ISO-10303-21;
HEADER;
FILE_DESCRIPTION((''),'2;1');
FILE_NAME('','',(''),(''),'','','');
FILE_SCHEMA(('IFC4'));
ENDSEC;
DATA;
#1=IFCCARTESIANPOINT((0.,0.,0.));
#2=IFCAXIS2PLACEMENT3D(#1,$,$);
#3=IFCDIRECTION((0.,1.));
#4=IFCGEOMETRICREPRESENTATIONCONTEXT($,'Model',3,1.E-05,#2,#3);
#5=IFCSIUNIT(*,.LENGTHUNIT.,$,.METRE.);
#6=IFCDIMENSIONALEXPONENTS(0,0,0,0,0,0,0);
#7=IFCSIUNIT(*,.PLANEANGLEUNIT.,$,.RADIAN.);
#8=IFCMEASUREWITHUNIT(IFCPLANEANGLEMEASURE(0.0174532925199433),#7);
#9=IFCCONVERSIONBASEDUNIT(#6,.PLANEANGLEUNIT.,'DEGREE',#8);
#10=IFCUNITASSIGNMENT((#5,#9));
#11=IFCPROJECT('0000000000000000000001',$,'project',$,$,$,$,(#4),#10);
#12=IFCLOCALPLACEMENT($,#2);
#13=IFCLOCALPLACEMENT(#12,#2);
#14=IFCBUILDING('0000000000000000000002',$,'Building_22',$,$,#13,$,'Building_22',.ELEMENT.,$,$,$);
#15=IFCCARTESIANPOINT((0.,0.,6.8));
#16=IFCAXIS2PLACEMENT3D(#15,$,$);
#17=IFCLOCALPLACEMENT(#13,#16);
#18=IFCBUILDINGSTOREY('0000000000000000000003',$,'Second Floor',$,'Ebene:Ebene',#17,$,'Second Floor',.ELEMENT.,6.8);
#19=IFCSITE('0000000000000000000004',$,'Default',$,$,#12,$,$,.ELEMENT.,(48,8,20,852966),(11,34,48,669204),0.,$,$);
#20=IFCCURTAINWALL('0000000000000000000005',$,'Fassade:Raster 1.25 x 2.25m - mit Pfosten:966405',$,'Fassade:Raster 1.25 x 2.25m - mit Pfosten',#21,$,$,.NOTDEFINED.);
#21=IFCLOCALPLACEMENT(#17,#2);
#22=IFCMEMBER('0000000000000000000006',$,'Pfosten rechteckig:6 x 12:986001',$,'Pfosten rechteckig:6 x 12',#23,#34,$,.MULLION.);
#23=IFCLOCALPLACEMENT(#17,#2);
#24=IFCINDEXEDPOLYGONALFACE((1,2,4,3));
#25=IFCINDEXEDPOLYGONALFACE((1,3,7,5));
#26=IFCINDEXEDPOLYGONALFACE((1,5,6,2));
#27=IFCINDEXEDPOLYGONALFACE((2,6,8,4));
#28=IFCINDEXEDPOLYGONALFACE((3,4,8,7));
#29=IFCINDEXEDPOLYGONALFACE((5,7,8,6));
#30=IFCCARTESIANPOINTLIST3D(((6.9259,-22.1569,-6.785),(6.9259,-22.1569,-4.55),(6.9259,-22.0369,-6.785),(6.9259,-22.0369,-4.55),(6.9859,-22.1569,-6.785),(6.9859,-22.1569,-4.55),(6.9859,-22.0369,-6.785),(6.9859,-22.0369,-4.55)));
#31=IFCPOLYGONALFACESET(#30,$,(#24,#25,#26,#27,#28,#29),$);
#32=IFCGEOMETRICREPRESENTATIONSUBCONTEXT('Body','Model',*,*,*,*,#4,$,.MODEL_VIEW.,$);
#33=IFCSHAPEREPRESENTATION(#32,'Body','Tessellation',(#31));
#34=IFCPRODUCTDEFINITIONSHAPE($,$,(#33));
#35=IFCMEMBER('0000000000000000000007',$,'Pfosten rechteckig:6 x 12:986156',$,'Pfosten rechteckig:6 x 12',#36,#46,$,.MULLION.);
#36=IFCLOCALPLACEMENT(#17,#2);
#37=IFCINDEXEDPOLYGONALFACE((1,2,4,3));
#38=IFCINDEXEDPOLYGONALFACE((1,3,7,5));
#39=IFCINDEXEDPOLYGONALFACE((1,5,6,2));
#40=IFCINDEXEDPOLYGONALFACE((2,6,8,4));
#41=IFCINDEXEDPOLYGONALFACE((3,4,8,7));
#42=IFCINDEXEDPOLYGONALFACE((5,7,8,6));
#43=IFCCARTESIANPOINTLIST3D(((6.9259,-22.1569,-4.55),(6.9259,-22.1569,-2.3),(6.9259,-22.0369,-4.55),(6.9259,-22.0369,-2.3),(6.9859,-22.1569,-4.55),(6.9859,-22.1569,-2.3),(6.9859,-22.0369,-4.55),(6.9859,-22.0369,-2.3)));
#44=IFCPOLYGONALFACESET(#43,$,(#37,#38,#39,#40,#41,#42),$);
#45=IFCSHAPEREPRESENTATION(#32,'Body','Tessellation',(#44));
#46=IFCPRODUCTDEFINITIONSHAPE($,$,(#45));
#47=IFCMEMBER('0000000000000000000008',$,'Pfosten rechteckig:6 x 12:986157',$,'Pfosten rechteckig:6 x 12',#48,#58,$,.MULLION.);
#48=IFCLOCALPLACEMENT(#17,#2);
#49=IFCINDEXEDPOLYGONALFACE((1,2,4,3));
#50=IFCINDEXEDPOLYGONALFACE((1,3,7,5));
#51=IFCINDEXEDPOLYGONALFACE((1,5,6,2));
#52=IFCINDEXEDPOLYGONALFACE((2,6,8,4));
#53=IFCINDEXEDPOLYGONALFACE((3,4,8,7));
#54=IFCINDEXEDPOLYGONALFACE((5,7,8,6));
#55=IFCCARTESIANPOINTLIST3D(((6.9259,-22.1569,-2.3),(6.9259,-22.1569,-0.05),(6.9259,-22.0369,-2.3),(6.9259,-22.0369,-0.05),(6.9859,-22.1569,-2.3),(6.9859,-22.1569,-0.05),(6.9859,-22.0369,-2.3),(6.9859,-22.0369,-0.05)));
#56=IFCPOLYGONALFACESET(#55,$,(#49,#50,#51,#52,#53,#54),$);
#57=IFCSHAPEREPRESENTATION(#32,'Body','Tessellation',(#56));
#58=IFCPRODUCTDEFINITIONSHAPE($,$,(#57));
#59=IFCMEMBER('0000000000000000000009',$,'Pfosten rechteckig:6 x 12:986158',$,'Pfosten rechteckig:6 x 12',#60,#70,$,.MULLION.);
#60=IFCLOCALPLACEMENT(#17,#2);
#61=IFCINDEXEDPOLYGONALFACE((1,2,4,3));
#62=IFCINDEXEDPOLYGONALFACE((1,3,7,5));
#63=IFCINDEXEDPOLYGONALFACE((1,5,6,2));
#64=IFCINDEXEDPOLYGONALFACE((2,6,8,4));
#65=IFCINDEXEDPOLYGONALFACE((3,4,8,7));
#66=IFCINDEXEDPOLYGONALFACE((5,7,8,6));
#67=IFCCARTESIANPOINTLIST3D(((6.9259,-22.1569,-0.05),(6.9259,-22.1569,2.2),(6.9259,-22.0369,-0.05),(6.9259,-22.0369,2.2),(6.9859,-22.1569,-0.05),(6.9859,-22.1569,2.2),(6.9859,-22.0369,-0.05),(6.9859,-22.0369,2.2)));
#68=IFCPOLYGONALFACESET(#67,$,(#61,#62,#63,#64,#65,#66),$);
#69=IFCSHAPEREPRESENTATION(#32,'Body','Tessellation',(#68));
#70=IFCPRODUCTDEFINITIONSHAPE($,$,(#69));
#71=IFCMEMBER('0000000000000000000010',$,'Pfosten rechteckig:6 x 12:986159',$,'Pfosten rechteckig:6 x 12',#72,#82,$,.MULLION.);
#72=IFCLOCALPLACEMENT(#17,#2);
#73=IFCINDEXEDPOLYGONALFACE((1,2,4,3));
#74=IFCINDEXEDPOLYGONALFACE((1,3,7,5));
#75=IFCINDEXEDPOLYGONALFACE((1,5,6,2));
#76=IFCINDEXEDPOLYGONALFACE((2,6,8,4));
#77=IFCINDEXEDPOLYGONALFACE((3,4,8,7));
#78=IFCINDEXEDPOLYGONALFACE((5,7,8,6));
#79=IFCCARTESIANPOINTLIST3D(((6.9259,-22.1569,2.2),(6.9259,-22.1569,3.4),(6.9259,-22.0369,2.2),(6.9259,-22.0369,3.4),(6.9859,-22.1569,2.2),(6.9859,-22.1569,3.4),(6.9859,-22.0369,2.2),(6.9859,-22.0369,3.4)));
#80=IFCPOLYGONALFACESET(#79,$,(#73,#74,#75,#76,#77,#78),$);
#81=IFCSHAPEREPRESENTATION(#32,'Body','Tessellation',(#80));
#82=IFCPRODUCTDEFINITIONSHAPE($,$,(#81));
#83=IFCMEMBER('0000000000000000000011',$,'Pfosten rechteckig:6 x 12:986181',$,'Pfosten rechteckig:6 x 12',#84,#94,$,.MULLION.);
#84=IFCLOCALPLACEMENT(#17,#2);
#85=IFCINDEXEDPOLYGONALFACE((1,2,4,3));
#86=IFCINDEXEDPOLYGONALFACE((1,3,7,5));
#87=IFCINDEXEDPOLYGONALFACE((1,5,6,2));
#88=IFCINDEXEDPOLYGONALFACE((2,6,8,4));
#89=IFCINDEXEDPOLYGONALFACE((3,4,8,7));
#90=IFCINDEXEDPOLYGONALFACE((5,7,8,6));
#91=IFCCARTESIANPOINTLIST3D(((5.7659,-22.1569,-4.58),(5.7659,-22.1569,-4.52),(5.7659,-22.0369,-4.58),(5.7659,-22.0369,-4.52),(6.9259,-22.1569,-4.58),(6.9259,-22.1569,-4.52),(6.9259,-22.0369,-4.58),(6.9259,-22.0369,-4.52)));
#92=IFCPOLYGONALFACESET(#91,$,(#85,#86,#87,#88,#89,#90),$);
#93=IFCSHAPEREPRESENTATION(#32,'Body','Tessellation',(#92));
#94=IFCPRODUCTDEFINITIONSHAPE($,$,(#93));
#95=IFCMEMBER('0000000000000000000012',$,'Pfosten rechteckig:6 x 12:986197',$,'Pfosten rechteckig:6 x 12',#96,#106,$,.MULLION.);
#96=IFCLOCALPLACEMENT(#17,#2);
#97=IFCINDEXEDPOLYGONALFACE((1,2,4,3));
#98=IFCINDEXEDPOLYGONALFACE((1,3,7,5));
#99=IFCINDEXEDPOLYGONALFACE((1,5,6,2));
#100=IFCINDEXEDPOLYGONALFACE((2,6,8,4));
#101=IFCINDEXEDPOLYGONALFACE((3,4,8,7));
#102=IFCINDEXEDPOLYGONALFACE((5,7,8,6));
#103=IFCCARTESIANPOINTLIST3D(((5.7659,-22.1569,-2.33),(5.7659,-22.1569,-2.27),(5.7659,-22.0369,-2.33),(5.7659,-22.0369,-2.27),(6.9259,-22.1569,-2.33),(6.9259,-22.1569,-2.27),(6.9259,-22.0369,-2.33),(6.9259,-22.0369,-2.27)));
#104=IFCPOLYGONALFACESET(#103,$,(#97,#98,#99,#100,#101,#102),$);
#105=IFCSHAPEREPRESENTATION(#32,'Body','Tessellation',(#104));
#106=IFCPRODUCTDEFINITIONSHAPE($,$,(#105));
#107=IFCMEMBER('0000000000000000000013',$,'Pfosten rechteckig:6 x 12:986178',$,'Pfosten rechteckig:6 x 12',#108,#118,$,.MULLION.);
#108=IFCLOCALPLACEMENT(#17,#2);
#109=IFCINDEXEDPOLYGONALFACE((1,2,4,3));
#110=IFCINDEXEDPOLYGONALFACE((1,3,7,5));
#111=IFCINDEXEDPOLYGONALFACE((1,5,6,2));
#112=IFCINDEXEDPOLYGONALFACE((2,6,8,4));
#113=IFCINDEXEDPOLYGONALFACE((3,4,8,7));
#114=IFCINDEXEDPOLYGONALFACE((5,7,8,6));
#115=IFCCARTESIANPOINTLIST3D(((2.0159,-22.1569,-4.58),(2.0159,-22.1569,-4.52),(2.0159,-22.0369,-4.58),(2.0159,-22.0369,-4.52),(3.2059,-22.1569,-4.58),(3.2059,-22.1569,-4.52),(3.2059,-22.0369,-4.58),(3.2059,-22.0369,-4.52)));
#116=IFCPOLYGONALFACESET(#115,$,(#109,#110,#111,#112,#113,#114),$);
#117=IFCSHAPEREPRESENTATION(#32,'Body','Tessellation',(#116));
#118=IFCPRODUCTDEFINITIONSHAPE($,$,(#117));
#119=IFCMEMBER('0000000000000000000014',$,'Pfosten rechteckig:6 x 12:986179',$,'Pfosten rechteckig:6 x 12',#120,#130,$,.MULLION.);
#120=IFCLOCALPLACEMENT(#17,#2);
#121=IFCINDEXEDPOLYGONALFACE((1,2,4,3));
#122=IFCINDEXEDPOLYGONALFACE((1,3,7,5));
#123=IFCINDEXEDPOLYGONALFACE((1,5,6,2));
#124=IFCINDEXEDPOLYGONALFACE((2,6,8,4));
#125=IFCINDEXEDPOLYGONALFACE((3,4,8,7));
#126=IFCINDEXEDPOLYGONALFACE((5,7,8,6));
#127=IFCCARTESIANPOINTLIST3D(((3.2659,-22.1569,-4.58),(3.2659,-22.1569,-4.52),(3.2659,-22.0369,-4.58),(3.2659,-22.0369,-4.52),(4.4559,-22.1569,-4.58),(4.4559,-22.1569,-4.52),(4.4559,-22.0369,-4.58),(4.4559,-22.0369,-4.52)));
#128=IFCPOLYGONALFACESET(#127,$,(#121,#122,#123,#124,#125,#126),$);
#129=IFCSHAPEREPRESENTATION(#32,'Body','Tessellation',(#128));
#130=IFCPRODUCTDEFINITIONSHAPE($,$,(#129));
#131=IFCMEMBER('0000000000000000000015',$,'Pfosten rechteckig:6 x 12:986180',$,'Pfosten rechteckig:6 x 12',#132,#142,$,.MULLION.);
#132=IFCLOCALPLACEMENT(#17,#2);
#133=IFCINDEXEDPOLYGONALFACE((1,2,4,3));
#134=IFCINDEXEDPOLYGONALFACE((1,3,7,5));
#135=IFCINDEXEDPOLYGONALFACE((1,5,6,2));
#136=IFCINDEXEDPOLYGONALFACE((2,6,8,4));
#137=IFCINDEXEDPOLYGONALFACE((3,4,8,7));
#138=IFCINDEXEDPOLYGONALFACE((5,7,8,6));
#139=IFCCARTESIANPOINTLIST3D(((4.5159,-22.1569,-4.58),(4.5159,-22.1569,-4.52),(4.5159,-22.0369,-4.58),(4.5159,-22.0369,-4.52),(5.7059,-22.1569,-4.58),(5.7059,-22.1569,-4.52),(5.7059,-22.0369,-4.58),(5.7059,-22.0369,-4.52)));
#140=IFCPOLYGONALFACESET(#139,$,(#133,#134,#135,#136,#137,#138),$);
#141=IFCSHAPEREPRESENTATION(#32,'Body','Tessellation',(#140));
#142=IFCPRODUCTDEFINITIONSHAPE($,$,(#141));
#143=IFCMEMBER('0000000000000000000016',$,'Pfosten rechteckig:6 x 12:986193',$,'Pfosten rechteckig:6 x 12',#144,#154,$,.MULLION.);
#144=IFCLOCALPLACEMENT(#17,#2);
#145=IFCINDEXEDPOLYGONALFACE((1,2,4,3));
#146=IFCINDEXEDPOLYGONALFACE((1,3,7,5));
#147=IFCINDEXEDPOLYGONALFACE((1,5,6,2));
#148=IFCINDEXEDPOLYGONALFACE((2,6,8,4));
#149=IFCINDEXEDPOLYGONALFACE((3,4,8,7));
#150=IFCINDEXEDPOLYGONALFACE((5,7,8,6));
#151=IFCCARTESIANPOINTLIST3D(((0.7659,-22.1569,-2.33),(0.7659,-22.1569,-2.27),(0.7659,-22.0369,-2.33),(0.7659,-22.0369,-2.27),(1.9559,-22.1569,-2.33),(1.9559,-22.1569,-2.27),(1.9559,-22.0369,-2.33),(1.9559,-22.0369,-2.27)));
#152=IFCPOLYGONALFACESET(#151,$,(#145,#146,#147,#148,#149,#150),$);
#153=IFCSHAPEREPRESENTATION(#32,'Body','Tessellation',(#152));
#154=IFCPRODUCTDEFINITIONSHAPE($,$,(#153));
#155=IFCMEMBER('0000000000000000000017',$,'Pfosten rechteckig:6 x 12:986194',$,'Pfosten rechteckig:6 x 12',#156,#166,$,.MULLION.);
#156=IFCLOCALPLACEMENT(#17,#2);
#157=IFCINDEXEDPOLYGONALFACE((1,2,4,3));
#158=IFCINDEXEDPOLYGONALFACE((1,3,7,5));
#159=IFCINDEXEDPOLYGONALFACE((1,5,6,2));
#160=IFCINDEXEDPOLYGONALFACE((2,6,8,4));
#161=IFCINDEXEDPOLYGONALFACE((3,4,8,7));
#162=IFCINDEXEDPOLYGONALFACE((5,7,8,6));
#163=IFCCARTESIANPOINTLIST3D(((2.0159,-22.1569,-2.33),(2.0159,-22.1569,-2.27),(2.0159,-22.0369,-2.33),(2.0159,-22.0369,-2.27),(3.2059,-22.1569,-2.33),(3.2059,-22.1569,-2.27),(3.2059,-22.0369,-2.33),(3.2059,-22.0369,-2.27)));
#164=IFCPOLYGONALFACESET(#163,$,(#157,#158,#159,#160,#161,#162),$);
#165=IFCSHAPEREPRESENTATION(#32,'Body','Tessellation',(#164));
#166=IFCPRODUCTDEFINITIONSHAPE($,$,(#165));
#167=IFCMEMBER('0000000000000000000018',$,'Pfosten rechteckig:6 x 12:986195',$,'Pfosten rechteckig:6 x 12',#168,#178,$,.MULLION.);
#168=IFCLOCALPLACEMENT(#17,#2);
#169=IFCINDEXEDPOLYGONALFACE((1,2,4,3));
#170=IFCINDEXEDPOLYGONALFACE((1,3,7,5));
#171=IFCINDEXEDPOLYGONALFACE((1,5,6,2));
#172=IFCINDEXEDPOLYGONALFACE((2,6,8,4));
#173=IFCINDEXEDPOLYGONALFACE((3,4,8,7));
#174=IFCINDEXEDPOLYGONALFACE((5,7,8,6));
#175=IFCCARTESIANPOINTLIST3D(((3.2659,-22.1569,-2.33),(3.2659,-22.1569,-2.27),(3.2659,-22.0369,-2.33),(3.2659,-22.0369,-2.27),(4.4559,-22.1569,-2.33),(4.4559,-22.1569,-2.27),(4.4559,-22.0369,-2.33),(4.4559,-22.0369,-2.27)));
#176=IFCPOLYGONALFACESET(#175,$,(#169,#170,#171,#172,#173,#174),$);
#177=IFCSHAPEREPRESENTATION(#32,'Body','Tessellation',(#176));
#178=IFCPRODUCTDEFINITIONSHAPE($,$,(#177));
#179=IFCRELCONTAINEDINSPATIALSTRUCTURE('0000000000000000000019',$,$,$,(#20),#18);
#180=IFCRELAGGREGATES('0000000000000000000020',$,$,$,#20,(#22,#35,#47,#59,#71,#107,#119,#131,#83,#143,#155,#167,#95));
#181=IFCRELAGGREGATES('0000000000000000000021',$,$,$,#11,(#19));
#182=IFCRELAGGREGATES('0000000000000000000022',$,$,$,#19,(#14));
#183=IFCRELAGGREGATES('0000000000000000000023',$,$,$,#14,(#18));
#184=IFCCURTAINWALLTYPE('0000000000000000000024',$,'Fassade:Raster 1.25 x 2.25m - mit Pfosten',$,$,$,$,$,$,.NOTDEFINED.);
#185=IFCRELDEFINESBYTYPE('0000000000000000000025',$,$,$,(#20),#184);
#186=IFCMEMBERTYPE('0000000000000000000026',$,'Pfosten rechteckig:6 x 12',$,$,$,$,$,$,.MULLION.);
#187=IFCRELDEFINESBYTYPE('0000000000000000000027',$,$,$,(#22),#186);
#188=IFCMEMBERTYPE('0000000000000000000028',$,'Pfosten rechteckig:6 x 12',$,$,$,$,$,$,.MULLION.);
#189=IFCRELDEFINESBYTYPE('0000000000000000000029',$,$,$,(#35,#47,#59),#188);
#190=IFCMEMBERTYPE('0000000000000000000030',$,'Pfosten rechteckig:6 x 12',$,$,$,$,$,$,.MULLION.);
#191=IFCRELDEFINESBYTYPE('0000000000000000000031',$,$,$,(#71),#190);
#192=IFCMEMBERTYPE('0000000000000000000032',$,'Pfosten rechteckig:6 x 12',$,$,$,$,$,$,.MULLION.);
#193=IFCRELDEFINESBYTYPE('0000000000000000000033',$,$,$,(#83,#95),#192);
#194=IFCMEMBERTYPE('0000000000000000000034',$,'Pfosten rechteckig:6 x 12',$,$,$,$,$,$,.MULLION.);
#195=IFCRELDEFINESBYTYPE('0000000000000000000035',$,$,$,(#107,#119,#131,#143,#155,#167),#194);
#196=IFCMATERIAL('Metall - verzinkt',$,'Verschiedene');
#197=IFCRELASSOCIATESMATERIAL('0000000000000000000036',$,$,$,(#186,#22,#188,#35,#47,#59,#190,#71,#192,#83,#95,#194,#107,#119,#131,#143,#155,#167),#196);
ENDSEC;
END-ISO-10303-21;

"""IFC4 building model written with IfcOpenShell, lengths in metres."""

from ifc_helpers import new_model, entity, si_unit, converted_unit, direction, frame, origin, place, context, subcontext, project, spatial, indexed_curve, outline, extrude, source, transform, mapped, material, type_object, type_shapes, element, aggregate, save


model = new_model("IFC4")

# Units and contexts
model_context = context("Model", 3, precision=1e-05, world=origin(), true_north=direction((0.0, 1.0)))
body_context = subcontext(model_context, "Body", "Model", "MODEL_VIEW")
ifc_project = project(units=[si_unit("LENGTHUNIT", "METRE"), converted_unit("PLANEANGLEUNIT", "DEGREE", entity("IfcPlaneAngleMeasure", 0.0174532925199433), si_unit("PLANEANGLEUNIT", "RADIAN"), dimensions=[0, 0, 0, 0, 0, 0, 0])], contexts=[model_context])

# Site, building, storey
site_placement = place(None, origin())
site = spatial("IfcSite", under=ifc_project, at=site_placement, Name="Default", CompositionType="ELEMENT", RefLatitude=(48, 8, 20, 852966), RefLongitude=(11, 34, 48, 669204), RefElevation=0.0)
building_placement = place(site_placement, origin())
building = spatial("IfcBuilding", under=site, at=building_placement, Name="Building_22", LongName="Building_22", CompositionType="ELEMENT")
storey_placement = place(building_placement, frame((0.0, 0.0, 6.8)))
storey = spatial("IfcBuildingStorey", under=building, at=storey_placement, Name="Second Floor", ObjectType="Ebene:Ebene", LongName="Second Floor", CompositionType="ELEMENT", Elevation=6.8)

# Curtain wall, members
curtain_wall_type = type_object("IfcCurtainWallType", Name="Fassade:Raster 1.25 x 2.25m - mit Pfosten", PredefinedType="NOTDEFINED")
curtain_wall_placement = place(storey_placement, frame((0.0, 0.0, -6.8)))
curtain_wall = element("IfcCurtainWall", 1, at=curtain_wall_placement, inside=storey, type_object=curtain_wall_type, Name="Fassade:Raster 1.25 x 2.25m - mit Pfosten:966405", ObjectType="Fassade:Raster 1.25 x 2.25m - mit Pfosten", PredefinedType="NOTDEFINED")
ifc_material_1 = material(Name="Metall - verzinkt", Category="Verschiedene")
member_type_1 = type_object("IfcMemberType", Name="Pfosten rechteckig:6 x 12", PredefinedType="MULLION", material=ifc_material_1)
shared_shape_1 = source(origin(), body_context, "Body", "SweptSolid", [
    extrude(outline(indexed_curve([(-0.03, -0.06), (0.03, -0.06), (0.03, 0.06), (-0.03, 0.06), (-0.03, -0.06)], self_intersect=False)), frame((-0.03, 0.0, -2.235), z_axis=(0.0, 0.0, 1.0), x_axis=(-1.0, 0.0, 0.0)), (0.0, 0.0, 1.0), 2.235),
])
type_shapes(member_type_1, [shared_shape_1])
member_1_placement = place(curtain_wall_placement, frame((6.9859, -22.0969, 0.015), z_axis=(0.0, 0.0, -1.0), x_axis=(1.0, 0.0, 0.0)))
member_1 = element("IfcMember", 2, at=member_1_placement, type_object=member_type_1, material=ifc_material_1, Name="Pfosten rechteckig:6 x 12:986001", ObjectType="Pfosten rechteckig:6 x 12", PredefinedType="MULLION", context=body_context, shape_type="MappedRepresentation", body=[
    mapped(shared_shape_1, transform((0.0, 0.0, 0.0), scale=1.0)),
])
member_type_2 = type_object("IfcMemberType", Name="Pfosten rechteckig:6 x 12", PredefinedType="MULLION", material=ifc_material_1)
shared_shape_2 = source(origin(), body_context, "Body", "SweptSolid", [
    extrude(outline(indexed_curve([(-0.03, -0.06), (0.03, -0.06), (0.03, 0.06), (-0.03, 0.06), (-0.03, -0.06)], self_intersect=False)), frame((-0.03, 0.0, -2.25), z_axis=(0.0, 0.0, 1.0), x_axis=(-1.0, 0.0, 0.0)), (0.0, 0.0, 1.0), 2.25),
])
type_shapes(member_type_2, [shared_shape_2])
member_2_placement = place(curtain_wall_placement, frame((6.9859, -22.0969, 2.25), z_axis=(0.0, 0.0, -1.0), x_axis=(1.0, 0.0, 0.0)))
member_2 = element("IfcMember", 3, at=member_2_placement, type_object=member_type_2, material=ifc_material_1, Name="Pfosten rechteckig:6 x 12:986156", ObjectType="Pfosten rechteckig:6 x 12", PredefinedType="MULLION", context=body_context, shape_type="MappedRepresentation", body=[
    mapped(shared_shape_2, transform((0.0, 0.0, 0.0), scale=1.0)),
])
member_3_placement = place(curtain_wall_placement, frame((6.9859, -22.0969, 4.5), z_axis=(0.0, 0.0, -1.0), x_axis=(1.0, 0.0, 0.0)))
member_3 = element("IfcMember", 4, at=member_3_placement, type_object=member_type_2, material=ifc_material_1, Name="Pfosten rechteckig:6 x 12:986157", ObjectType="Pfosten rechteckig:6 x 12", PredefinedType="MULLION", context=body_context, shape_type="MappedRepresentation", body=[
    mapped(shared_shape_2, transform((0.0, 0.0, 0.0), scale=1.0)),
])
member_4_placement = place(curtain_wall_placement, frame((6.9859, -22.0969, 6.75), z_axis=(0.0, 0.0, -1.0), x_axis=(1.0, 0.0, 0.0)))
member_4 = element("IfcMember", 5, at=member_4_placement, type_object=member_type_2, material=ifc_material_1, Name="Pfosten rechteckig:6 x 12:986158", ObjectType="Pfosten rechteckig:6 x 12", PredefinedType="MULLION", context=body_context, shape_type="MappedRepresentation", body=[
    mapped(shared_shape_2, transform((0.0, 0.0, 0.0), scale=1.0)),
])
member_type_3 = type_object("IfcMemberType", Name="Pfosten rechteckig:6 x 12", PredefinedType="MULLION", material=ifc_material_1)
shared_shape_3 = source(origin(), body_context, "Body", "SweptSolid", [
    extrude(outline(indexed_curve([(-0.03, -0.06), (0.03, -0.06), (0.03, 0.06), (-0.03, 0.06), (-0.03, -0.06)], self_intersect=False)), frame((-0.03, 0.0, -1.2), z_axis=(0.0, 0.0, 1.0), x_axis=(-1.0, 0.0, 0.0)), (0.0, 0.0, 1.0), 1.2),
])
type_shapes(member_type_3, [shared_shape_3])
member_5_placement = place(curtain_wall_placement, frame((6.9859, -22.0969, 9.0), z_axis=(0.0, 0.0, -1.0), x_axis=(1.0, 0.0, 0.0)))
member_5 = element("IfcMember", 6, at=member_5_placement, type_object=member_type_3, material=ifc_material_1, Name="Pfosten rechteckig:6 x 12:986159", ObjectType="Pfosten rechteckig:6 x 12", PredefinedType="MULLION", context=body_context, shape_type="MappedRepresentation", body=[
    mapped(shared_shape_3, transform((0.0, 0.0, 0.0), scale=1.0)),
])
member_type_4 = type_object("IfcMemberType", Name="Pfosten rechteckig:6 x 12", PredefinedType="MULLION", material=ifc_material_1)
shared_shape_4 = source(origin(), body_context, "Body", "SweptSolid", [
    extrude(outline(indexed_curve([(-0.03, -0.06), (0.03, -0.06), (0.03, 0.06), (-0.03, 0.06), (-0.03, -0.06)], self_intersect=False)), frame((0.0, 0.0, -1.16), z_axis=(0.0, 0.0, 1.0), x_axis=(-1.0, 0.0, 0.0)), (0.0, 0.0, 1.0), 1.16),
])
type_shapes(member_type_4, [shared_shape_4])
member_6_placement = place(curtain_wall_placement, frame((6.9259, -22.0969, 2.25), z_axis=(1.0, 0.0, 0.0), x_axis=(0.0, 0.0, 1.0)))
member_6 = element("IfcMember", 7, at=member_6_placement, type_object=member_type_4, material=ifc_material_1, Name="Pfosten rechteckig:6 x 12:986181", ObjectType="Pfosten rechteckig:6 x 12", PredefinedType="MULLION", context=body_context, shape_type="MappedRepresentation", body=[
    mapped(shared_shape_4, transform((0.0, 0.0, 0.0), scale=1.0)),
])
member_7_placement = place(curtain_wall_placement, frame((6.9259, -22.0969, 4.5), z_axis=(1.0, 0.0, 0.0), x_axis=(0.0, 0.0, 1.0)))
member_7 = element("IfcMember", 8, at=member_7_placement, type_object=member_type_4, material=ifc_material_1, Name="Pfosten rechteckig:6 x 12:986197", ObjectType="Pfosten rechteckig:6 x 12", PredefinedType="MULLION", context=body_context, shape_type="MappedRepresentation", body=[
    mapped(shared_shape_4, transform((0.0, 0.0, 0.0), scale=1.0)),
])
member_type_5 = type_object("IfcMemberType", Name="Pfosten rechteckig:6 x 12", PredefinedType="MULLION", material=ifc_material_1)
shared_shape_5 = source(origin(), body_context, "Body", "SweptSolid", [
    extrude(outline(indexed_curve([(-0.03, -0.06), (0.03, -0.06), (0.03, 0.06), (-0.03, 0.06), (-0.03, -0.06)], self_intersect=False)), frame((0.0, 0.0, -1.19), z_axis=(0.0, 0.0, 1.0), x_axis=(-1.0, 0.0, 0.0)), (0.0, 0.0, 1.0), 1.19),
])
type_shapes(member_type_5, [shared_shape_5])
member_8_placement = place(curtain_wall_placement, frame((3.2059, -22.0969, 2.25), z_axis=(1.0, 0.0, 0.0), x_axis=(0.0, 0.0, 1.0)))
member_8 = element("IfcMember", 9, at=member_8_placement, type_object=member_type_5, material=ifc_material_1, Name="Pfosten rechteckig:6 x 12:986178", ObjectType="Pfosten rechteckig:6 x 12", PredefinedType="MULLION", context=body_context, shape_type="MappedRepresentation", body=[
    mapped(shared_shape_5, transform((0.0, 0.0, 0.0), scale=1.0)),
])
member_9_placement = place(curtain_wall_placement, frame((4.4559, -22.0969, 2.25), z_axis=(1.0, 0.0, 0.0), x_axis=(0.0, 0.0, 1.0)))
member_9 = element("IfcMember", 10, at=member_9_placement, type_object=member_type_5, material=ifc_material_1, Name="Pfosten rechteckig:6 x 12:986179", ObjectType="Pfosten rechteckig:6 x 12", PredefinedType="MULLION", context=body_context, shape_type="MappedRepresentation", body=[
    mapped(shared_shape_5, transform((0.0, 0.0, 0.0), scale=1.0)),
])
member_10_placement = place(curtain_wall_placement, frame((5.7059, -22.0969, 2.25), z_axis=(1.0, 0.0, 0.0), x_axis=(0.0, 0.0, 1.0)))
member_10 = element("IfcMember", 11, at=member_10_placement, type_object=member_type_5, material=ifc_material_1, Name="Pfosten rechteckig:6 x 12:986180", ObjectType="Pfosten rechteckig:6 x 12", PredefinedType="MULLION", context=body_context, shape_type="MappedRepresentation", body=[
    mapped(shared_shape_5, transform((0.0, 0.0, 0.0), scale=1.0)),
])
member_11_placement = place(curtain_wall_placement, frame((1.9559, -22.0969, 4.5), z_axis=(1.0, 0.0, 0.0), x_axis=(0.0, 0.0, 1.0)))
member_11 = element("IfcMember", 12, at=member_11_placement, type_object=member_type_5, material=ifc_material_1, Name="Pfosten rechteckig:6 x 12:986193", ObjectType="Pfosten rechteckig:6 x 12", PredefinedType="MULLION", context=body_context, shape_type="MappedRepresentation", body=[
    mapped(shared_shape_5, transform((0.0, 0.0, 0.0), scale=1.0)),
])
member_12_placement = place(curtain_wall_placement, frame((3.2059, -22.0969, 4.5), z_axis=(1.0, 0.0, 0.0), x_axis=(0.0, 0.0, 1.0)))
member_12 = element("IfcMember", 13, at=member_12_placement, type_object=member_type_5, material=ifc_material_1, Name="Pfosten rechteckig:6 x 12:986194", ObjectType="Pfosten rechteckig:6 x 12", PredefinedType="MULLION", context=body_context, shape_type="MappedRepresentation", body=[
    mapped(shared_shape_5, transform((0.0, 0.0, 0.0), scale=1.0)),
])
member_13_placement = place(curtain_wall_placement, frame((4.4559, -22.0969, 4.5), z_axis=(1.0, 0.0, 0.0), x_axis=(0.0, 0.0, 1.0)))
member_13 = element("IfcMember", 14, at=member_13_placement, type_object=member_type_5, material=ifc_material_1, Name="Pfosten rechteckig:6 x 12:986195", ObjectType="Pfosten rechteckig:6 x 12", PredefinedType="MULLION", context=body_context, shape_type="MappedRepresentation", body=[
    mapped(shared_shape_5, transform((0.0, 0.0, 0.0), scale=1.0)),
])
aggregate(curtain_wall, [member_1, member_2, member_3, member_4, member_5, member_8, member_9, member_10, member_6, member_11, member_12, member_13, member_7])

save(model, "model.ifc")
